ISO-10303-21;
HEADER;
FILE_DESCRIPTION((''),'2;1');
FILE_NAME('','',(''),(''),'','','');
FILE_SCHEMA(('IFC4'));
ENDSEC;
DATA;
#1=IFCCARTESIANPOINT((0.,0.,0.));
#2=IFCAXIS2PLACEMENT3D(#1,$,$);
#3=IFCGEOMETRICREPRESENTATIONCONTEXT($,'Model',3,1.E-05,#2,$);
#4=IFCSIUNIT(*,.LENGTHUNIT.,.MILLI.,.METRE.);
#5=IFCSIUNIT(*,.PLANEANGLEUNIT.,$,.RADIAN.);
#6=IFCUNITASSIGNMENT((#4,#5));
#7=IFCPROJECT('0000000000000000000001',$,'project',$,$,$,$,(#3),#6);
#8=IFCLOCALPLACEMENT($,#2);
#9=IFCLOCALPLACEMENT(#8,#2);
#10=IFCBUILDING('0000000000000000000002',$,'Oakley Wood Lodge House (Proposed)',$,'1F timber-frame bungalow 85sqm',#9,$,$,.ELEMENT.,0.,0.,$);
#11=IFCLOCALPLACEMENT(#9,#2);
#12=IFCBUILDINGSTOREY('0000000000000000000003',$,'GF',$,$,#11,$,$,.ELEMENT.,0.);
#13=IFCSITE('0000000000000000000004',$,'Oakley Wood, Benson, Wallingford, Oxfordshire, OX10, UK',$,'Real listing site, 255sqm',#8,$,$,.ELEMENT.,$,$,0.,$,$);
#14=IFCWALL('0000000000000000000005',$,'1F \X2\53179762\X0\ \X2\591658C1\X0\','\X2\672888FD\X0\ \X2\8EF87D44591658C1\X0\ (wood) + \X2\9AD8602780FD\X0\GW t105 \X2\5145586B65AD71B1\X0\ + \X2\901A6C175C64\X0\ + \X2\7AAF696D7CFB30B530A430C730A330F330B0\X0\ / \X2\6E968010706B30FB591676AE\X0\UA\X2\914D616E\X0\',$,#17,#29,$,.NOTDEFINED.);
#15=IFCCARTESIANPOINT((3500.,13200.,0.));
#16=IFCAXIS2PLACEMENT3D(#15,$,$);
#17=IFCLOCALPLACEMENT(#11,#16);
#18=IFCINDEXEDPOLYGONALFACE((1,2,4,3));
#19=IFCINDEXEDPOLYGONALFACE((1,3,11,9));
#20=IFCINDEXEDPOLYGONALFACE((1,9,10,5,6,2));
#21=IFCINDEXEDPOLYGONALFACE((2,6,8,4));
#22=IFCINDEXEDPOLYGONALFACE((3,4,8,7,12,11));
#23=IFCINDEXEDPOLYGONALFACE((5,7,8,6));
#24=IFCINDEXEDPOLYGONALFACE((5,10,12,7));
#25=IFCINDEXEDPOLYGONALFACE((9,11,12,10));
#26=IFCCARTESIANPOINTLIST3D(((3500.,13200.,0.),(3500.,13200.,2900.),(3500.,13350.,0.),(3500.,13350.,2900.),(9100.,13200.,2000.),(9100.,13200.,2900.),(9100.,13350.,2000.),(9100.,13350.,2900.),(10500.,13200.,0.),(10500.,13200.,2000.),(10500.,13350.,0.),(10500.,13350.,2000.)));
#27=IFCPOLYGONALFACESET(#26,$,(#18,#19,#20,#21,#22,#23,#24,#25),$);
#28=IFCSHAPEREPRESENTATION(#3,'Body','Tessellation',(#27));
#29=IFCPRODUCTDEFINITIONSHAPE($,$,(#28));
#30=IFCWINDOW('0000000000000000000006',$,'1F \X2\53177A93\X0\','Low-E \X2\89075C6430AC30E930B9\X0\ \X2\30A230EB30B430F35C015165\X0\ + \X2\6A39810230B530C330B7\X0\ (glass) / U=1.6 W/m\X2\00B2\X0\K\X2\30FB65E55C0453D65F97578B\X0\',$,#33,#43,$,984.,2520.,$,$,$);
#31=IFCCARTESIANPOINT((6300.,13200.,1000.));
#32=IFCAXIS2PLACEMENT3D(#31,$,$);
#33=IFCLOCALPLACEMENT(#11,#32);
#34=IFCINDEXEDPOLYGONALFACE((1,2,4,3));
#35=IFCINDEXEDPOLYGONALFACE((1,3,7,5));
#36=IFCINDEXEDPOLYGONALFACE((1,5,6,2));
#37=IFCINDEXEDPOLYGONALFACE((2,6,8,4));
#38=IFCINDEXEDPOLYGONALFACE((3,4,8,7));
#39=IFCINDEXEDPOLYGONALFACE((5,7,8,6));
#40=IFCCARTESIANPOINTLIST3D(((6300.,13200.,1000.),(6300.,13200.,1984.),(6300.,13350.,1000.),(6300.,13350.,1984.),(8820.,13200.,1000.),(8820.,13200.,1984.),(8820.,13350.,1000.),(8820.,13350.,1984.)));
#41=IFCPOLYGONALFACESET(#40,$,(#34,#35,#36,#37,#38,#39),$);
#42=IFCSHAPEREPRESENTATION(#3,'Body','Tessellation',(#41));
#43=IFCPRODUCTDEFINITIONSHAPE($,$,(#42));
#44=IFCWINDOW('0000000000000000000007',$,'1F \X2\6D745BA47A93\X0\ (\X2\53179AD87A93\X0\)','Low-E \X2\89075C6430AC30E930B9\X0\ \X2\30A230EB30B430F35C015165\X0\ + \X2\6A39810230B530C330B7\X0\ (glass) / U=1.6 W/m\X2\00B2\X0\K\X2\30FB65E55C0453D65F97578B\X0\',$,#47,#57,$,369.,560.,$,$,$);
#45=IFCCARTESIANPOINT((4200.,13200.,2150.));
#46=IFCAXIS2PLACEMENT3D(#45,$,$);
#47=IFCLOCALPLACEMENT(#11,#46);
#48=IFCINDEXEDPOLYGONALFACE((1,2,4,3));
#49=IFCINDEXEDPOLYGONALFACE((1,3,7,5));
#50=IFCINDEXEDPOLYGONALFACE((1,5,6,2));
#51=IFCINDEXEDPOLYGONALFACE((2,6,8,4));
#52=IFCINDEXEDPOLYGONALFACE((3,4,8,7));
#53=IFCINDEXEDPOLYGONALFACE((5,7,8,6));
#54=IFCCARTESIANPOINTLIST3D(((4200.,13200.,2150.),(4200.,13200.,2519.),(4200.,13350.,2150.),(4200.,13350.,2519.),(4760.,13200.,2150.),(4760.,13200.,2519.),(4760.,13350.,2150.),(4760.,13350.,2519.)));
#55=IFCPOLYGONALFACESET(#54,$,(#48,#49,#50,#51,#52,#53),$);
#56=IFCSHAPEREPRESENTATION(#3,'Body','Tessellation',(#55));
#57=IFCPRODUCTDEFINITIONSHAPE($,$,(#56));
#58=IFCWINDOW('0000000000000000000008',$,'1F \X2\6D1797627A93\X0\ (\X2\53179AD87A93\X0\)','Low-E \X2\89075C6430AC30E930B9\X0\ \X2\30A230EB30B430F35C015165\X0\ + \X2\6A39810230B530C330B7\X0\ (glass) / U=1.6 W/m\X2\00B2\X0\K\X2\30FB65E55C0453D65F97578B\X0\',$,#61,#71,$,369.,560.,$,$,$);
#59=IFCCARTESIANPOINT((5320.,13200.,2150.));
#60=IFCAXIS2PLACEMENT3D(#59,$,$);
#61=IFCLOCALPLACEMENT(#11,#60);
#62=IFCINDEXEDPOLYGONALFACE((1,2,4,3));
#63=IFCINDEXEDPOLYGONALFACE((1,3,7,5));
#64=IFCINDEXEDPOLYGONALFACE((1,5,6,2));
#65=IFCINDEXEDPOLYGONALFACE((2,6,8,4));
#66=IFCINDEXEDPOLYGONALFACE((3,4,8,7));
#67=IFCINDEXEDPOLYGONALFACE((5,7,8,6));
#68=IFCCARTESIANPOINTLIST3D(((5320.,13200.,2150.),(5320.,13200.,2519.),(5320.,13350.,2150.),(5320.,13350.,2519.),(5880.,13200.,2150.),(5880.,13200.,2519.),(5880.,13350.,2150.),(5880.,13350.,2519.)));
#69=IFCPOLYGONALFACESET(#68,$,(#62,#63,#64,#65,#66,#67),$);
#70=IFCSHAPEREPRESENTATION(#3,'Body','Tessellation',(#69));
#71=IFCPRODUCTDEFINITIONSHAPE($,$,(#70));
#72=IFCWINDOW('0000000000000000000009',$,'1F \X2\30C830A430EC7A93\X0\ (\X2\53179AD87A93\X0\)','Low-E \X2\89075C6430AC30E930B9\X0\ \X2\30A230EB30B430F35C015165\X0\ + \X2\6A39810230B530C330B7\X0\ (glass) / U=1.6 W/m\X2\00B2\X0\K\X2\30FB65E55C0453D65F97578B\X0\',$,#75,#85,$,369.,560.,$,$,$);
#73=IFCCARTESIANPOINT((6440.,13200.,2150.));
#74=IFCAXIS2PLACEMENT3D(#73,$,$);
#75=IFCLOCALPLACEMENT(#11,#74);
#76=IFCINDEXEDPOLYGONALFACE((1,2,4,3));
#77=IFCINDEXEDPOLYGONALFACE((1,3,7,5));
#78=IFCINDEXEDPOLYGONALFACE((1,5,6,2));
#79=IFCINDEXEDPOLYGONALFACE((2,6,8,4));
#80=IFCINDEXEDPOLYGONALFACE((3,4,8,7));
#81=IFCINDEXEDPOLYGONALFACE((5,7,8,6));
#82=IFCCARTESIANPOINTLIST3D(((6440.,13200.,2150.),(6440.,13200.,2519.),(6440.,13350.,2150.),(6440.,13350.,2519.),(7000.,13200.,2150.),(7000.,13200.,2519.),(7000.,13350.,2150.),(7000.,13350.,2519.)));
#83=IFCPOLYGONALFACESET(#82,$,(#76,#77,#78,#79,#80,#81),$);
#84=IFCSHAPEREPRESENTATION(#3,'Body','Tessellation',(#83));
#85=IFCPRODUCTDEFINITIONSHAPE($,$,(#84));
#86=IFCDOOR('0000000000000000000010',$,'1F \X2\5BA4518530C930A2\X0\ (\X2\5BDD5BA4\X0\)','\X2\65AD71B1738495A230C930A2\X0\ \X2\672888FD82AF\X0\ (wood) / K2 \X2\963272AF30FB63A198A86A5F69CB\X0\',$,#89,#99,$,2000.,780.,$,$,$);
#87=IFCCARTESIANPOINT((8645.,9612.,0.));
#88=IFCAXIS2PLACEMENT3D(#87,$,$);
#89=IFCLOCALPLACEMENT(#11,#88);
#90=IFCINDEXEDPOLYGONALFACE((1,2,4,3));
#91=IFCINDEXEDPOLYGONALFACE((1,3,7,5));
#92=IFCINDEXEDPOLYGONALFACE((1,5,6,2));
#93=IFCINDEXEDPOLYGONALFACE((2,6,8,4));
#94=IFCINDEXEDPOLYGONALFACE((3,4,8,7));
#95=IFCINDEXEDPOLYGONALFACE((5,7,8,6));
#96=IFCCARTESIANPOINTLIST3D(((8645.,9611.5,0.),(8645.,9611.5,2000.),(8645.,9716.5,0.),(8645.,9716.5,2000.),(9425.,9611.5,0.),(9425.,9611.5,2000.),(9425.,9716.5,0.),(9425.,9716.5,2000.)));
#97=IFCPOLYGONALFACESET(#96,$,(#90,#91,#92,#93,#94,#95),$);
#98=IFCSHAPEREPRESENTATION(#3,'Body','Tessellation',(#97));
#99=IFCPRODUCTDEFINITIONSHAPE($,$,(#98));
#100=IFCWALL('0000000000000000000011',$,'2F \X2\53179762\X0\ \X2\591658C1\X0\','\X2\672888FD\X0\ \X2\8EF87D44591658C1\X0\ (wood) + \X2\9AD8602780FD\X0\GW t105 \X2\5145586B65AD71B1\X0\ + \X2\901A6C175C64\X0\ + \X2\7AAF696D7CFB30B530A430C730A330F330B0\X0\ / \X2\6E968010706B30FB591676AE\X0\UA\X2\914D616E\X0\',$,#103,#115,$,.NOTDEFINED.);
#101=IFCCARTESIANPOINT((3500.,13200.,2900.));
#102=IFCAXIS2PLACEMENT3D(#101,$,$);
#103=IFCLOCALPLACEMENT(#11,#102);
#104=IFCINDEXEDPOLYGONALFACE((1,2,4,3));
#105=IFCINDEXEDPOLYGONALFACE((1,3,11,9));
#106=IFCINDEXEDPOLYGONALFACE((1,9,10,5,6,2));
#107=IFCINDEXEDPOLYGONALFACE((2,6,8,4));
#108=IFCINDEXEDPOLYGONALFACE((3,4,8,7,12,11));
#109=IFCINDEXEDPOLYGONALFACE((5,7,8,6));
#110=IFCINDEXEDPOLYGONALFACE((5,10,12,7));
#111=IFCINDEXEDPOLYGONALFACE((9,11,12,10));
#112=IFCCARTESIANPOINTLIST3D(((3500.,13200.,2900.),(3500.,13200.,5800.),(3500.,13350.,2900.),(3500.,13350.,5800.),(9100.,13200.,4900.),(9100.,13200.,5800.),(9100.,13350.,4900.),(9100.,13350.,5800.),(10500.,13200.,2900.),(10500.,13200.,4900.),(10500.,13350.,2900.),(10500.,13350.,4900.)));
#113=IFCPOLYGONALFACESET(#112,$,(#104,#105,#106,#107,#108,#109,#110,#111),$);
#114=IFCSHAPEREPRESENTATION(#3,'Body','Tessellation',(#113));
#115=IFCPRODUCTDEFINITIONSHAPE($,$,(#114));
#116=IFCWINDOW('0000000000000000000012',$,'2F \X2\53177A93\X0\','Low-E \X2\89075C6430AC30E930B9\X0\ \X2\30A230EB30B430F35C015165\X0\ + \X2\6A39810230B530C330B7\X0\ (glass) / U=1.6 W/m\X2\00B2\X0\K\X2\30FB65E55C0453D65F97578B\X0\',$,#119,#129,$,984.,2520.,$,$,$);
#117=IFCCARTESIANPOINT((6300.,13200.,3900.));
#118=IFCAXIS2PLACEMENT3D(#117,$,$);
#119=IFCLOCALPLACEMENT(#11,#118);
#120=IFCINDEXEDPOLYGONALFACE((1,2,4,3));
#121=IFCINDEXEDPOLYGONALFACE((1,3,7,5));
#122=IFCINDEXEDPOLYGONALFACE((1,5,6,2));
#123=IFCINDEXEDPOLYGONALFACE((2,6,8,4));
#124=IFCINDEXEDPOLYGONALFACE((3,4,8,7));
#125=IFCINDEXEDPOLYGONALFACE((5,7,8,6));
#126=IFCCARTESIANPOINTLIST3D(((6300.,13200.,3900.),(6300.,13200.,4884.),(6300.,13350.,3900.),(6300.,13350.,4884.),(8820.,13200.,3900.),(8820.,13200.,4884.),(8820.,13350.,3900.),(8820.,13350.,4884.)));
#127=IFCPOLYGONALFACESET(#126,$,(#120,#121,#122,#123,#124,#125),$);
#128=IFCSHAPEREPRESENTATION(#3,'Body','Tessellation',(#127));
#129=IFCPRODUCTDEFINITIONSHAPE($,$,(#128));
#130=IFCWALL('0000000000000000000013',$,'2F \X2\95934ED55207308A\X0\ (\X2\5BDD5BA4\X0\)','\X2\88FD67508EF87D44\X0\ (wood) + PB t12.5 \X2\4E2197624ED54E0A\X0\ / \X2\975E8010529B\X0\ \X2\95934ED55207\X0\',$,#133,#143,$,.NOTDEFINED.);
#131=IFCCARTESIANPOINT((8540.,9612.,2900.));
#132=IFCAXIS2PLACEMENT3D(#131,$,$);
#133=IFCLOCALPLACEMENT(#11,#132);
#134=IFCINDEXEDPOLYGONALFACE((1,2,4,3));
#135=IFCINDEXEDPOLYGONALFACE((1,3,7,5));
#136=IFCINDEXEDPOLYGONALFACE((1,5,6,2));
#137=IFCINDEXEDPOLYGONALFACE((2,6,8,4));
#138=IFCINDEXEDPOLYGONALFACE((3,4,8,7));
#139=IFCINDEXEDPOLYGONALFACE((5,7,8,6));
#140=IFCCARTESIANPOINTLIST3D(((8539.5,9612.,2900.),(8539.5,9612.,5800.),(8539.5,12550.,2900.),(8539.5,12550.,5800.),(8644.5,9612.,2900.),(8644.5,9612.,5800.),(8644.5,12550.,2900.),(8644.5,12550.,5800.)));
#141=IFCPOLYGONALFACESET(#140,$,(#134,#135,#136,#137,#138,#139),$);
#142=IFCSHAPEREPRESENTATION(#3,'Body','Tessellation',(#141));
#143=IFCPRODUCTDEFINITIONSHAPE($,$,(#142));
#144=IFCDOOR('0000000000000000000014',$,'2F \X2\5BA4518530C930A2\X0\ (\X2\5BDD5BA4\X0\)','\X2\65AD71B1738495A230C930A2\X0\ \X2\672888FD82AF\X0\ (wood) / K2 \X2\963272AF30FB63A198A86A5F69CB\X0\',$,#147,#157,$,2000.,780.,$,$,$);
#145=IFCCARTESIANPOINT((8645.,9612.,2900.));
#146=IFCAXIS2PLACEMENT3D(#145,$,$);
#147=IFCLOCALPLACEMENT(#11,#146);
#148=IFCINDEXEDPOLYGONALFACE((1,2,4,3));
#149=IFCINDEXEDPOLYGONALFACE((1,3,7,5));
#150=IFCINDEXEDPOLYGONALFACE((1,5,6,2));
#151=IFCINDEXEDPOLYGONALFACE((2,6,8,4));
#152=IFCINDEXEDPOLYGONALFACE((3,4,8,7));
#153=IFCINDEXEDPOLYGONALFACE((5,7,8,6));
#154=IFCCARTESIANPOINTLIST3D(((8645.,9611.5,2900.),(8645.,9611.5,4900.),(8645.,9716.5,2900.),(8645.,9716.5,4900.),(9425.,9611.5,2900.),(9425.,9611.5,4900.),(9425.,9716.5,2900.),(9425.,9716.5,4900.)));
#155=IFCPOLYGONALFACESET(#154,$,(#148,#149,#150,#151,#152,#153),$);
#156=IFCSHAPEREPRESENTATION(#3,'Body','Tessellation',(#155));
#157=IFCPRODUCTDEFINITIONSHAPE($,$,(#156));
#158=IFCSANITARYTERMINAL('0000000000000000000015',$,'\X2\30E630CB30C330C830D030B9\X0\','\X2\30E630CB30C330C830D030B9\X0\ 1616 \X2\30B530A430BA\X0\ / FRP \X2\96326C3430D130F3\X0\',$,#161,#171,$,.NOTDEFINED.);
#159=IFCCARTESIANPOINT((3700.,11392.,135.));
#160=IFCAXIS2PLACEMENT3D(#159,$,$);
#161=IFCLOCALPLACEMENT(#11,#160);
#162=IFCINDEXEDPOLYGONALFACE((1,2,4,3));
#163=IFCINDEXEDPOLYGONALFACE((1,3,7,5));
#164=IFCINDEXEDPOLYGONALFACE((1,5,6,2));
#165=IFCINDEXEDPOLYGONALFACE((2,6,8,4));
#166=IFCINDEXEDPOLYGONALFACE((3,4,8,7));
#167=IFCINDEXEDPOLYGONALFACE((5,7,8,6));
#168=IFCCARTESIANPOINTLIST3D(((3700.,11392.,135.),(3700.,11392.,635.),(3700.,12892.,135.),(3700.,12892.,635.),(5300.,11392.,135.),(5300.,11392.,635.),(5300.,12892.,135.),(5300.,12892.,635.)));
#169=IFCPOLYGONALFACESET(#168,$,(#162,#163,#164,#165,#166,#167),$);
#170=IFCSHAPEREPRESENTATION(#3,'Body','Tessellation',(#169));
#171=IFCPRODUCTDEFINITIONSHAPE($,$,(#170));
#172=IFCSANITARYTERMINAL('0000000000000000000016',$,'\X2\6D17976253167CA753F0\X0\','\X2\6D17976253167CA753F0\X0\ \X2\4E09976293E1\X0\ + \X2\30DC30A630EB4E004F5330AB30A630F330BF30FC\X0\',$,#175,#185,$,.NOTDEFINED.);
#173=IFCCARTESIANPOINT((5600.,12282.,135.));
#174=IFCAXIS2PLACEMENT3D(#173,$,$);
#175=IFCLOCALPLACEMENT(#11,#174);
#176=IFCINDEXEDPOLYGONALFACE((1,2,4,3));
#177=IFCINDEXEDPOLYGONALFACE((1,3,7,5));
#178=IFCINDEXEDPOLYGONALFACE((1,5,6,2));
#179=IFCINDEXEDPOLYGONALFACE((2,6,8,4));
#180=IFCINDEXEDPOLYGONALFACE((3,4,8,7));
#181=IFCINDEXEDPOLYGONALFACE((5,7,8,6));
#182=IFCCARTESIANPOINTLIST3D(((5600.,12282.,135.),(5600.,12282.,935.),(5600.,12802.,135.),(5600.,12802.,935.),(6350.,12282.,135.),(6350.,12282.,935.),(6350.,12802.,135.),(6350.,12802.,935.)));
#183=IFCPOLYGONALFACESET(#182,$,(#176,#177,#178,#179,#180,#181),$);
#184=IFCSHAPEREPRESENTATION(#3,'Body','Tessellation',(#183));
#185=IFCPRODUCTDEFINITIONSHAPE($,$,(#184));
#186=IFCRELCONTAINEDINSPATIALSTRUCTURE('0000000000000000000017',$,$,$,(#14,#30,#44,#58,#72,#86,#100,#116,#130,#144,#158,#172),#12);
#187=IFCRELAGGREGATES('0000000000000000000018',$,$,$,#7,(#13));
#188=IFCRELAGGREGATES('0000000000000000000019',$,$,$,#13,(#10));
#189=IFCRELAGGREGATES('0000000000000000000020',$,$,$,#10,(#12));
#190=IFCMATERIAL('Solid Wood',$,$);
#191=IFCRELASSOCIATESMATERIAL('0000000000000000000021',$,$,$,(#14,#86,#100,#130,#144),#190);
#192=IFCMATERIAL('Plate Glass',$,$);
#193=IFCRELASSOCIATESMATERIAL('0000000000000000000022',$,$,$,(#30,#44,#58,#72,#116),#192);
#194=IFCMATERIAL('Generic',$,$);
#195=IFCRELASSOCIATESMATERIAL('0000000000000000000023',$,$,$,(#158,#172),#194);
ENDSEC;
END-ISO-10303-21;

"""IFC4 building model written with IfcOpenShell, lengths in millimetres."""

from ifc_helpers import new_model, si_unit, frame, frame_2d, origin, place, context, project, spatial, rectangle, extrude, material, element, fill, save


model = new_model("IFC4")

# Units and contexts
model_context = context("Model", 3, precision=1e-05, world=origin())
ifc_project = project(units=[si_unit("LENGTHUNIT", "METRE", prefix="MILLI"), si_unit("PLANEANGLEUNIT", "RADIAN")], contexts=[model_context])

# Site, building, storey
site_placement = place(None, origin())
site = spatial("IfcSite", under=ifc_project, at=site_placement, Name="Oakley Wood, Benson, Wallingford, Oxfordshire, OX10, UK", ObjectType="Real listing site, 255sqm", CompositionType="ELEMENT", RefElevation=0.0)
building_placement = place(site_placement, origin())
building = spatial("IfcBuilding", under=site, at=building_placement, Name="Oakley Wood Lodge House (Proposed)", ObjectType="1F timber-frame bungalow 85sqm", CompositionType="ELEMENT", ElevationOfRefHeight=0.0, ElevationOfTerrain=0.0)
storey_placement = place(building_placement, origin())
storey = spatial("IfcBuildingStorey", under=building, at=storey_placement, Name="GF", CompositionType="ELEMENT", Elevation=0.0)

# Wall, openings, windows
ifc_material_1 = material(Name="Solid Wood")
wall_1_placement = place(storey_placement, frame((3500.0, 13200.0, 0.0)))
wall_1 = element("IfcWall", 1, at=wall_1_placement, inside=storey, material=ifc_material_1, Name="1F 北面 外壁", Description="木製 軸組外壁 (wood) + 高性能GW t105 充填断熱 + 通気層 + 窯業系サイディング / 準耐火・外皮UA配慮", PredefinedType="NOTDEFINED", context=model_context, shape_type="SweptSolid", body=[
    extrude(rectangle(XDim=7000.0, YDim=150.0, at=frame_2d((3500.0, 75.0))), frame((3500.0, 13200.0, 0.0)), (0.0, 0.0, 1.0), 2900.0),
])
opening_1_placement = place(storey_placement, frame((6300.0, 13200.0, 1000.0)))
opening_1 = element("IfcOpeningElement", 2, at=opening_1_placement, cuts=wall_1, PredefinedType="NOTDEFINED", context=model_context, shape_type="SweptSolid", body=[
    extrude(rectangle(XDim=2520.0, YDim=150.0, at=frame_2d((1260.0, 75.0))), frame((6300.0, 13200.0, 1000.0)), (0.0, 0.0, 1.0), 984.0),
])
opening_2_placement = place(storey_placement, frame((4200.0, 13200.0, 2150.0)))
opening_2 = element("IfcOpeningElement", 3, at=opening_2_placement, cuts=wall_1, PredefinedType="NOTDEFINED", context=model_context, shape_type="SweptSolid", body=[
    extrude(rectangle(XDim=560.0, YDim=150.0, at=frame_2d((280.0, 75.0))), frame((4200.0, 13200.0, 2150.0)), (0.0, 0.0, 1.0), 369.0),
])
opening_3_placement = place(storey_placement, frame((5320.0, 13200.0, 2150.0)))
opening_3 = element("IfcOpeningElement", 4, at=opening_3_placement, cuts=wall_1, PredefinedType="NOTDEFINED", context=model_context, shape_type="SweptSolid", body=[
    extrude(rectangle(XDim=560.0, YDim=150.0, at=frame_2d((280.0, 75.0))), frame((5320.0, 13200.0, 2150.0)), (0.0, 0.0, 1.0), 369.0),
])
opening_4_placement = place(storey_placement, frame((6440.0, 13200.0, 2150.0)))
opening_4 = element("IfcOpeningElement", 5, at=opening_4_placement, cuts=wall_1, PredefinedType="NOTDEFINED", context=model_context, shape_type="SweptSolid", body=[
    extrude(rectangle(XDim=560.0, YDim=150.0, at=frame_2d((280.0, 75.0))), frame((6440.0, 13200.0, 2150.0)), (0.0, 0.0, 1.0), 369.0),
])
ifc_material_2 = material(Name="Plate Glass")
window_1_placement = place(storey_placement, frame((6300.0, 13200.0, 1000.0)))
window_1 = element("IfcWindow", 6, at=window_1_placement, inside=storey, material=ifc_material_2, Name="1F 北窓", Description="Low-E 複層ガラス アルゴン封入 + 樹脂サッシ (glass) / U=1.6 W/m²K・日射取得型", OverallHeight=984.0, OverallWidth=2520.0, context=model_context, shape_type="SweptSolid", body=[
    extrude(rectangle(XDim=2520.0, YDim=150.0, at=frame_2d((1260.0, 75.0))), frame((6300.0, 13200.0, 1000.0)), (0.0, 0.0, 1.0), 984.0),
])
fill(opening_1, window_1)
window_2_placement = place(storey_placement, frame((4200.0, 13200.0, 2150.0)))
window_2 = element("IfcWindow", 7, at=window_2_placement, inside=storey, material=ifc_material_2, Name="1F 浴室窓 (北高窓)", Description="Low-E 複層ガラス アルゴン封入 + 樹脂サッシ (glass) / U=1.6 W/m²K・日射取得型", OverallHeight=369.0, OverallWidth=560.0, context=model_context, shape_type="SweptSolid", body=[
    extrude(rectangle(XDim=560.0, YDim=150.0, at=frame_2d((280.0, 75.0))), frame((4200.0, 13200.0, 2150.0)), (0.0, 0.0, 1.0), 369.0),
])
fill(opening_2, window_2)
window_3_placement = place(storey_placement, frame((5320.0, 13200.0, 2150.0)))
window_3 = element("IfcWindow", 8, at=window_3_placement, inside=storey, material=ifc_material_2, Name="1F 洗面窓 (北高窓)", Description="Low-E 複層ガラス アルゴン封入 + 樹脂サッシ (glass) / U=1.6 W/m²K・日射取得型", OverallHeight=369.0, OverallWidth=560.0, context=model_context, shape_type="SweptSolid", body=[
    extrude(rectangle(XDim=560.0, YDim=150.0, at=frame_2d((280.0, 75.0))), frame((5320.0, 13200.0, 2150.0)), (0.0, 0.0, 1.0), 369.0),
])
fill(opening_3, window_3)
window_4_placement = place(storey_placement, frame((6440.0, 13200.0, 2150.0)))
window_4 = element("IfcWindow", 9, at=window_4_placement, inside=storey, material=ifc_material_2, Name="1F トイレ窓 (北高窓)", Description="Low-E 複層ガラス アルゴン封入 + 樹脂サッシ (glass) / U=1.6 W/m²K・日射取得型", OverallHeight=369.0, OverallWidth=560.0, context=model_context, shape_type="SweptSolid", body=[
    extrude(rectangle(XDim=560.0, YDim=150.0, at=frame_2d((280.0, 75.0))), frame((6440.0, 13200.0, 2150.0)), (0.0, 0.0, 1.0), 369.0),
])
fill(opening_4, window_4)

# Door
door_1_placement = place(storey_placement, frame((8645.0, 9612.0, 0.0)))
element("IfcDoor", 10, at=door_1_placement, inside=storey, material=ifc_material_1, Name="1F 室内ドア (寝室)", Description="断熱玄関ドア 木製芯 (wood) / K2 防犯・採風機構", OverallHeight=2000.0, OverallWidth=780.0, context=model_context, shape_type="SweptSolid", body=[
    extrude(rectangle(XDim=780.0, YDim=105.0, at=frame_2d((390.0, 52.0))), frame((8645.0, 9612.0, 0.0)), (0.0, 0.0, 1.0), 2000.0),
])

# Wall, opening, window
wall_2_placement = place(storey_placement, frame((3500.0, 13200.0, 2900.0)))
wall_2 = element("IfcWall", 11, at=wall_2_placement, inside=storey, material=ifc_material_1, Name="2F 北面 外壁", Description="木製 軸組外壁 (wood) + 高性能GW t105 充填断熱 + 通気層 + 窯業系サイディング / 準耐火・外皮UA配慮", PredefinedType="NOTDEFINED", context=model_context, shape_type="SweptSolid", body=[
    extrude(rectangle(XDim=7000.0, YDim=150.0, at=frame_2d((3500.0, 75.0))), frame((3500.0, 13200.0, 2900.0)), (0.0, 0.0, 1.0), 2900.0),
])
opening_5_placement = place(storey_placement, frame((6300.0, 13200.0, 3900.0)))
opening_5 = element("IfcOpeningElement", 12, at=opening_5_placement, cuts=wall_2, PredefinedType="NOTDEFINED", context=model_context, shape_type="SweptSolid", body=[
    extrude(rectangle(XDim=2520.0, YDim=150.0, at=frame_2d((1260.0, 75.0))), frame((6300.0, 13200.0, 3900.0)), (0.0, 0.0, 1.0), 984.0),
])
window_5_placement = place(storey_placement, frame((6300.0, 13200.0, 3900.0)))
window_5 = element("IfcWindow", 13, at=window_5_placement, inside=storey, material=ifc_material_2, Name="2F 北窓", Description="Low-E 複層ガラス アルゴン封入 + 樹脂サッシ (glass) / U=1.6 W/m²K・日射取得型", OverallHeight=984.0, OverallWidth=2520.0, context=model_context, shape_type="SweptSolid", body=[
    extrude(rectangle(XDim=2520.0, YDim=150.0, at=frame_2d((1260.0, 75.0))), frame((6300.0, 13200.0, 3900.0)), (0.0, 0.0, 1.0), 984.0),
])
fill(opening_5, window_5)

# Wall
wall_3_placement = place(storey_placement, frame((8540.0, 9612.0, 2900.0)))
element("IfcWall", 14, at=wall_3_placement, inside=storey, material=ifc_material_1, Name="2F 間仕切り (寝室)", Description="製材軸組 (wood) + PB t12.5 両面仕上 / 非耐力 間仕切", PredefinedType="NOTDEFINED", context=model_context, shape_type="SweptSolid", body=[
    extrude(rectangle(XDim=105.0, YDim=2938.0, at=frame_2d((52.0, 1469.0))), frame((8540.0, 9612.0, 2900.0)), (0.0, 0.0, 1.0), 2900.0),
])

# Door
door_2_placement = place(storey_placement, frame((8645.0, 9612.0, 2900.0)))
element("IfcDoor", 15, at=door_2_placement, inside=storey, material=ifc_material_1, Name="2F 室内ドア (寝室)", Description="断熱玄関ドア 木製芯 (wood) / K2 防犯・採風機構", OverallHeight=2000.0, OverallWidth=780.0, context=model_context, shape_type="SweptSolid", body=[
    extrude(rectangle(XDim=780.0, YDim=105.0, at=frame_2d((390.0, 52.0))), frame((8645.0, 9612.0, 2900.0)), (0.0, 0.0, 1.0), 2000.0),
])

# Sanitary terminals
ifc_material_3 = material(Name="Generic")
sanitary_terminal_1_placement = place(storey_placement, frame((3700.0, 11392.0, 135.0)))
element("IfcSanitaryTerminal", 16, at=sanitary_terminal_1_placement, inside=storey, material=ifc_material_3, Name="ユニットバス", Description="ユニットバス 1616 サイズ / FRP 防水パン", PredefinedType="NOTDEFINED", context=model_context, shape_type="SweptSolid", body=[
    extrude(rectangle(XDim=1600.0, YDim=1500.0, at=frame_2d((800.0, 750.0))), frame((3700.0, 11392.0, 135.0)), (0.0, 0.0, 1.0), 500.0),
])
sanitary_terminal_2_placement = place(storey_placement, frame((5600.0, 12282.0, 135.0)))
element("IfcSanitaryTerminal", 17, at=sanitary_terminal_2_placement, inside=storey, material=ifc_material_3, Name="洗面化粧台", Description="洗面化粧台 三面鏡 + ボウル一体カウンター", PredefinedType="NOTDEFINED", context=model_context, shape_type="SweptSolid", body=[
    extrude(rectangle(XDim=750.0, YDim=520.0, at=frame_2d((375.0, 260.0))), frame((5600.0, 12282.0, 135.0)), (0.0, 0.0, 1.0), 800.0),
])

save(model, "model.ifc")
